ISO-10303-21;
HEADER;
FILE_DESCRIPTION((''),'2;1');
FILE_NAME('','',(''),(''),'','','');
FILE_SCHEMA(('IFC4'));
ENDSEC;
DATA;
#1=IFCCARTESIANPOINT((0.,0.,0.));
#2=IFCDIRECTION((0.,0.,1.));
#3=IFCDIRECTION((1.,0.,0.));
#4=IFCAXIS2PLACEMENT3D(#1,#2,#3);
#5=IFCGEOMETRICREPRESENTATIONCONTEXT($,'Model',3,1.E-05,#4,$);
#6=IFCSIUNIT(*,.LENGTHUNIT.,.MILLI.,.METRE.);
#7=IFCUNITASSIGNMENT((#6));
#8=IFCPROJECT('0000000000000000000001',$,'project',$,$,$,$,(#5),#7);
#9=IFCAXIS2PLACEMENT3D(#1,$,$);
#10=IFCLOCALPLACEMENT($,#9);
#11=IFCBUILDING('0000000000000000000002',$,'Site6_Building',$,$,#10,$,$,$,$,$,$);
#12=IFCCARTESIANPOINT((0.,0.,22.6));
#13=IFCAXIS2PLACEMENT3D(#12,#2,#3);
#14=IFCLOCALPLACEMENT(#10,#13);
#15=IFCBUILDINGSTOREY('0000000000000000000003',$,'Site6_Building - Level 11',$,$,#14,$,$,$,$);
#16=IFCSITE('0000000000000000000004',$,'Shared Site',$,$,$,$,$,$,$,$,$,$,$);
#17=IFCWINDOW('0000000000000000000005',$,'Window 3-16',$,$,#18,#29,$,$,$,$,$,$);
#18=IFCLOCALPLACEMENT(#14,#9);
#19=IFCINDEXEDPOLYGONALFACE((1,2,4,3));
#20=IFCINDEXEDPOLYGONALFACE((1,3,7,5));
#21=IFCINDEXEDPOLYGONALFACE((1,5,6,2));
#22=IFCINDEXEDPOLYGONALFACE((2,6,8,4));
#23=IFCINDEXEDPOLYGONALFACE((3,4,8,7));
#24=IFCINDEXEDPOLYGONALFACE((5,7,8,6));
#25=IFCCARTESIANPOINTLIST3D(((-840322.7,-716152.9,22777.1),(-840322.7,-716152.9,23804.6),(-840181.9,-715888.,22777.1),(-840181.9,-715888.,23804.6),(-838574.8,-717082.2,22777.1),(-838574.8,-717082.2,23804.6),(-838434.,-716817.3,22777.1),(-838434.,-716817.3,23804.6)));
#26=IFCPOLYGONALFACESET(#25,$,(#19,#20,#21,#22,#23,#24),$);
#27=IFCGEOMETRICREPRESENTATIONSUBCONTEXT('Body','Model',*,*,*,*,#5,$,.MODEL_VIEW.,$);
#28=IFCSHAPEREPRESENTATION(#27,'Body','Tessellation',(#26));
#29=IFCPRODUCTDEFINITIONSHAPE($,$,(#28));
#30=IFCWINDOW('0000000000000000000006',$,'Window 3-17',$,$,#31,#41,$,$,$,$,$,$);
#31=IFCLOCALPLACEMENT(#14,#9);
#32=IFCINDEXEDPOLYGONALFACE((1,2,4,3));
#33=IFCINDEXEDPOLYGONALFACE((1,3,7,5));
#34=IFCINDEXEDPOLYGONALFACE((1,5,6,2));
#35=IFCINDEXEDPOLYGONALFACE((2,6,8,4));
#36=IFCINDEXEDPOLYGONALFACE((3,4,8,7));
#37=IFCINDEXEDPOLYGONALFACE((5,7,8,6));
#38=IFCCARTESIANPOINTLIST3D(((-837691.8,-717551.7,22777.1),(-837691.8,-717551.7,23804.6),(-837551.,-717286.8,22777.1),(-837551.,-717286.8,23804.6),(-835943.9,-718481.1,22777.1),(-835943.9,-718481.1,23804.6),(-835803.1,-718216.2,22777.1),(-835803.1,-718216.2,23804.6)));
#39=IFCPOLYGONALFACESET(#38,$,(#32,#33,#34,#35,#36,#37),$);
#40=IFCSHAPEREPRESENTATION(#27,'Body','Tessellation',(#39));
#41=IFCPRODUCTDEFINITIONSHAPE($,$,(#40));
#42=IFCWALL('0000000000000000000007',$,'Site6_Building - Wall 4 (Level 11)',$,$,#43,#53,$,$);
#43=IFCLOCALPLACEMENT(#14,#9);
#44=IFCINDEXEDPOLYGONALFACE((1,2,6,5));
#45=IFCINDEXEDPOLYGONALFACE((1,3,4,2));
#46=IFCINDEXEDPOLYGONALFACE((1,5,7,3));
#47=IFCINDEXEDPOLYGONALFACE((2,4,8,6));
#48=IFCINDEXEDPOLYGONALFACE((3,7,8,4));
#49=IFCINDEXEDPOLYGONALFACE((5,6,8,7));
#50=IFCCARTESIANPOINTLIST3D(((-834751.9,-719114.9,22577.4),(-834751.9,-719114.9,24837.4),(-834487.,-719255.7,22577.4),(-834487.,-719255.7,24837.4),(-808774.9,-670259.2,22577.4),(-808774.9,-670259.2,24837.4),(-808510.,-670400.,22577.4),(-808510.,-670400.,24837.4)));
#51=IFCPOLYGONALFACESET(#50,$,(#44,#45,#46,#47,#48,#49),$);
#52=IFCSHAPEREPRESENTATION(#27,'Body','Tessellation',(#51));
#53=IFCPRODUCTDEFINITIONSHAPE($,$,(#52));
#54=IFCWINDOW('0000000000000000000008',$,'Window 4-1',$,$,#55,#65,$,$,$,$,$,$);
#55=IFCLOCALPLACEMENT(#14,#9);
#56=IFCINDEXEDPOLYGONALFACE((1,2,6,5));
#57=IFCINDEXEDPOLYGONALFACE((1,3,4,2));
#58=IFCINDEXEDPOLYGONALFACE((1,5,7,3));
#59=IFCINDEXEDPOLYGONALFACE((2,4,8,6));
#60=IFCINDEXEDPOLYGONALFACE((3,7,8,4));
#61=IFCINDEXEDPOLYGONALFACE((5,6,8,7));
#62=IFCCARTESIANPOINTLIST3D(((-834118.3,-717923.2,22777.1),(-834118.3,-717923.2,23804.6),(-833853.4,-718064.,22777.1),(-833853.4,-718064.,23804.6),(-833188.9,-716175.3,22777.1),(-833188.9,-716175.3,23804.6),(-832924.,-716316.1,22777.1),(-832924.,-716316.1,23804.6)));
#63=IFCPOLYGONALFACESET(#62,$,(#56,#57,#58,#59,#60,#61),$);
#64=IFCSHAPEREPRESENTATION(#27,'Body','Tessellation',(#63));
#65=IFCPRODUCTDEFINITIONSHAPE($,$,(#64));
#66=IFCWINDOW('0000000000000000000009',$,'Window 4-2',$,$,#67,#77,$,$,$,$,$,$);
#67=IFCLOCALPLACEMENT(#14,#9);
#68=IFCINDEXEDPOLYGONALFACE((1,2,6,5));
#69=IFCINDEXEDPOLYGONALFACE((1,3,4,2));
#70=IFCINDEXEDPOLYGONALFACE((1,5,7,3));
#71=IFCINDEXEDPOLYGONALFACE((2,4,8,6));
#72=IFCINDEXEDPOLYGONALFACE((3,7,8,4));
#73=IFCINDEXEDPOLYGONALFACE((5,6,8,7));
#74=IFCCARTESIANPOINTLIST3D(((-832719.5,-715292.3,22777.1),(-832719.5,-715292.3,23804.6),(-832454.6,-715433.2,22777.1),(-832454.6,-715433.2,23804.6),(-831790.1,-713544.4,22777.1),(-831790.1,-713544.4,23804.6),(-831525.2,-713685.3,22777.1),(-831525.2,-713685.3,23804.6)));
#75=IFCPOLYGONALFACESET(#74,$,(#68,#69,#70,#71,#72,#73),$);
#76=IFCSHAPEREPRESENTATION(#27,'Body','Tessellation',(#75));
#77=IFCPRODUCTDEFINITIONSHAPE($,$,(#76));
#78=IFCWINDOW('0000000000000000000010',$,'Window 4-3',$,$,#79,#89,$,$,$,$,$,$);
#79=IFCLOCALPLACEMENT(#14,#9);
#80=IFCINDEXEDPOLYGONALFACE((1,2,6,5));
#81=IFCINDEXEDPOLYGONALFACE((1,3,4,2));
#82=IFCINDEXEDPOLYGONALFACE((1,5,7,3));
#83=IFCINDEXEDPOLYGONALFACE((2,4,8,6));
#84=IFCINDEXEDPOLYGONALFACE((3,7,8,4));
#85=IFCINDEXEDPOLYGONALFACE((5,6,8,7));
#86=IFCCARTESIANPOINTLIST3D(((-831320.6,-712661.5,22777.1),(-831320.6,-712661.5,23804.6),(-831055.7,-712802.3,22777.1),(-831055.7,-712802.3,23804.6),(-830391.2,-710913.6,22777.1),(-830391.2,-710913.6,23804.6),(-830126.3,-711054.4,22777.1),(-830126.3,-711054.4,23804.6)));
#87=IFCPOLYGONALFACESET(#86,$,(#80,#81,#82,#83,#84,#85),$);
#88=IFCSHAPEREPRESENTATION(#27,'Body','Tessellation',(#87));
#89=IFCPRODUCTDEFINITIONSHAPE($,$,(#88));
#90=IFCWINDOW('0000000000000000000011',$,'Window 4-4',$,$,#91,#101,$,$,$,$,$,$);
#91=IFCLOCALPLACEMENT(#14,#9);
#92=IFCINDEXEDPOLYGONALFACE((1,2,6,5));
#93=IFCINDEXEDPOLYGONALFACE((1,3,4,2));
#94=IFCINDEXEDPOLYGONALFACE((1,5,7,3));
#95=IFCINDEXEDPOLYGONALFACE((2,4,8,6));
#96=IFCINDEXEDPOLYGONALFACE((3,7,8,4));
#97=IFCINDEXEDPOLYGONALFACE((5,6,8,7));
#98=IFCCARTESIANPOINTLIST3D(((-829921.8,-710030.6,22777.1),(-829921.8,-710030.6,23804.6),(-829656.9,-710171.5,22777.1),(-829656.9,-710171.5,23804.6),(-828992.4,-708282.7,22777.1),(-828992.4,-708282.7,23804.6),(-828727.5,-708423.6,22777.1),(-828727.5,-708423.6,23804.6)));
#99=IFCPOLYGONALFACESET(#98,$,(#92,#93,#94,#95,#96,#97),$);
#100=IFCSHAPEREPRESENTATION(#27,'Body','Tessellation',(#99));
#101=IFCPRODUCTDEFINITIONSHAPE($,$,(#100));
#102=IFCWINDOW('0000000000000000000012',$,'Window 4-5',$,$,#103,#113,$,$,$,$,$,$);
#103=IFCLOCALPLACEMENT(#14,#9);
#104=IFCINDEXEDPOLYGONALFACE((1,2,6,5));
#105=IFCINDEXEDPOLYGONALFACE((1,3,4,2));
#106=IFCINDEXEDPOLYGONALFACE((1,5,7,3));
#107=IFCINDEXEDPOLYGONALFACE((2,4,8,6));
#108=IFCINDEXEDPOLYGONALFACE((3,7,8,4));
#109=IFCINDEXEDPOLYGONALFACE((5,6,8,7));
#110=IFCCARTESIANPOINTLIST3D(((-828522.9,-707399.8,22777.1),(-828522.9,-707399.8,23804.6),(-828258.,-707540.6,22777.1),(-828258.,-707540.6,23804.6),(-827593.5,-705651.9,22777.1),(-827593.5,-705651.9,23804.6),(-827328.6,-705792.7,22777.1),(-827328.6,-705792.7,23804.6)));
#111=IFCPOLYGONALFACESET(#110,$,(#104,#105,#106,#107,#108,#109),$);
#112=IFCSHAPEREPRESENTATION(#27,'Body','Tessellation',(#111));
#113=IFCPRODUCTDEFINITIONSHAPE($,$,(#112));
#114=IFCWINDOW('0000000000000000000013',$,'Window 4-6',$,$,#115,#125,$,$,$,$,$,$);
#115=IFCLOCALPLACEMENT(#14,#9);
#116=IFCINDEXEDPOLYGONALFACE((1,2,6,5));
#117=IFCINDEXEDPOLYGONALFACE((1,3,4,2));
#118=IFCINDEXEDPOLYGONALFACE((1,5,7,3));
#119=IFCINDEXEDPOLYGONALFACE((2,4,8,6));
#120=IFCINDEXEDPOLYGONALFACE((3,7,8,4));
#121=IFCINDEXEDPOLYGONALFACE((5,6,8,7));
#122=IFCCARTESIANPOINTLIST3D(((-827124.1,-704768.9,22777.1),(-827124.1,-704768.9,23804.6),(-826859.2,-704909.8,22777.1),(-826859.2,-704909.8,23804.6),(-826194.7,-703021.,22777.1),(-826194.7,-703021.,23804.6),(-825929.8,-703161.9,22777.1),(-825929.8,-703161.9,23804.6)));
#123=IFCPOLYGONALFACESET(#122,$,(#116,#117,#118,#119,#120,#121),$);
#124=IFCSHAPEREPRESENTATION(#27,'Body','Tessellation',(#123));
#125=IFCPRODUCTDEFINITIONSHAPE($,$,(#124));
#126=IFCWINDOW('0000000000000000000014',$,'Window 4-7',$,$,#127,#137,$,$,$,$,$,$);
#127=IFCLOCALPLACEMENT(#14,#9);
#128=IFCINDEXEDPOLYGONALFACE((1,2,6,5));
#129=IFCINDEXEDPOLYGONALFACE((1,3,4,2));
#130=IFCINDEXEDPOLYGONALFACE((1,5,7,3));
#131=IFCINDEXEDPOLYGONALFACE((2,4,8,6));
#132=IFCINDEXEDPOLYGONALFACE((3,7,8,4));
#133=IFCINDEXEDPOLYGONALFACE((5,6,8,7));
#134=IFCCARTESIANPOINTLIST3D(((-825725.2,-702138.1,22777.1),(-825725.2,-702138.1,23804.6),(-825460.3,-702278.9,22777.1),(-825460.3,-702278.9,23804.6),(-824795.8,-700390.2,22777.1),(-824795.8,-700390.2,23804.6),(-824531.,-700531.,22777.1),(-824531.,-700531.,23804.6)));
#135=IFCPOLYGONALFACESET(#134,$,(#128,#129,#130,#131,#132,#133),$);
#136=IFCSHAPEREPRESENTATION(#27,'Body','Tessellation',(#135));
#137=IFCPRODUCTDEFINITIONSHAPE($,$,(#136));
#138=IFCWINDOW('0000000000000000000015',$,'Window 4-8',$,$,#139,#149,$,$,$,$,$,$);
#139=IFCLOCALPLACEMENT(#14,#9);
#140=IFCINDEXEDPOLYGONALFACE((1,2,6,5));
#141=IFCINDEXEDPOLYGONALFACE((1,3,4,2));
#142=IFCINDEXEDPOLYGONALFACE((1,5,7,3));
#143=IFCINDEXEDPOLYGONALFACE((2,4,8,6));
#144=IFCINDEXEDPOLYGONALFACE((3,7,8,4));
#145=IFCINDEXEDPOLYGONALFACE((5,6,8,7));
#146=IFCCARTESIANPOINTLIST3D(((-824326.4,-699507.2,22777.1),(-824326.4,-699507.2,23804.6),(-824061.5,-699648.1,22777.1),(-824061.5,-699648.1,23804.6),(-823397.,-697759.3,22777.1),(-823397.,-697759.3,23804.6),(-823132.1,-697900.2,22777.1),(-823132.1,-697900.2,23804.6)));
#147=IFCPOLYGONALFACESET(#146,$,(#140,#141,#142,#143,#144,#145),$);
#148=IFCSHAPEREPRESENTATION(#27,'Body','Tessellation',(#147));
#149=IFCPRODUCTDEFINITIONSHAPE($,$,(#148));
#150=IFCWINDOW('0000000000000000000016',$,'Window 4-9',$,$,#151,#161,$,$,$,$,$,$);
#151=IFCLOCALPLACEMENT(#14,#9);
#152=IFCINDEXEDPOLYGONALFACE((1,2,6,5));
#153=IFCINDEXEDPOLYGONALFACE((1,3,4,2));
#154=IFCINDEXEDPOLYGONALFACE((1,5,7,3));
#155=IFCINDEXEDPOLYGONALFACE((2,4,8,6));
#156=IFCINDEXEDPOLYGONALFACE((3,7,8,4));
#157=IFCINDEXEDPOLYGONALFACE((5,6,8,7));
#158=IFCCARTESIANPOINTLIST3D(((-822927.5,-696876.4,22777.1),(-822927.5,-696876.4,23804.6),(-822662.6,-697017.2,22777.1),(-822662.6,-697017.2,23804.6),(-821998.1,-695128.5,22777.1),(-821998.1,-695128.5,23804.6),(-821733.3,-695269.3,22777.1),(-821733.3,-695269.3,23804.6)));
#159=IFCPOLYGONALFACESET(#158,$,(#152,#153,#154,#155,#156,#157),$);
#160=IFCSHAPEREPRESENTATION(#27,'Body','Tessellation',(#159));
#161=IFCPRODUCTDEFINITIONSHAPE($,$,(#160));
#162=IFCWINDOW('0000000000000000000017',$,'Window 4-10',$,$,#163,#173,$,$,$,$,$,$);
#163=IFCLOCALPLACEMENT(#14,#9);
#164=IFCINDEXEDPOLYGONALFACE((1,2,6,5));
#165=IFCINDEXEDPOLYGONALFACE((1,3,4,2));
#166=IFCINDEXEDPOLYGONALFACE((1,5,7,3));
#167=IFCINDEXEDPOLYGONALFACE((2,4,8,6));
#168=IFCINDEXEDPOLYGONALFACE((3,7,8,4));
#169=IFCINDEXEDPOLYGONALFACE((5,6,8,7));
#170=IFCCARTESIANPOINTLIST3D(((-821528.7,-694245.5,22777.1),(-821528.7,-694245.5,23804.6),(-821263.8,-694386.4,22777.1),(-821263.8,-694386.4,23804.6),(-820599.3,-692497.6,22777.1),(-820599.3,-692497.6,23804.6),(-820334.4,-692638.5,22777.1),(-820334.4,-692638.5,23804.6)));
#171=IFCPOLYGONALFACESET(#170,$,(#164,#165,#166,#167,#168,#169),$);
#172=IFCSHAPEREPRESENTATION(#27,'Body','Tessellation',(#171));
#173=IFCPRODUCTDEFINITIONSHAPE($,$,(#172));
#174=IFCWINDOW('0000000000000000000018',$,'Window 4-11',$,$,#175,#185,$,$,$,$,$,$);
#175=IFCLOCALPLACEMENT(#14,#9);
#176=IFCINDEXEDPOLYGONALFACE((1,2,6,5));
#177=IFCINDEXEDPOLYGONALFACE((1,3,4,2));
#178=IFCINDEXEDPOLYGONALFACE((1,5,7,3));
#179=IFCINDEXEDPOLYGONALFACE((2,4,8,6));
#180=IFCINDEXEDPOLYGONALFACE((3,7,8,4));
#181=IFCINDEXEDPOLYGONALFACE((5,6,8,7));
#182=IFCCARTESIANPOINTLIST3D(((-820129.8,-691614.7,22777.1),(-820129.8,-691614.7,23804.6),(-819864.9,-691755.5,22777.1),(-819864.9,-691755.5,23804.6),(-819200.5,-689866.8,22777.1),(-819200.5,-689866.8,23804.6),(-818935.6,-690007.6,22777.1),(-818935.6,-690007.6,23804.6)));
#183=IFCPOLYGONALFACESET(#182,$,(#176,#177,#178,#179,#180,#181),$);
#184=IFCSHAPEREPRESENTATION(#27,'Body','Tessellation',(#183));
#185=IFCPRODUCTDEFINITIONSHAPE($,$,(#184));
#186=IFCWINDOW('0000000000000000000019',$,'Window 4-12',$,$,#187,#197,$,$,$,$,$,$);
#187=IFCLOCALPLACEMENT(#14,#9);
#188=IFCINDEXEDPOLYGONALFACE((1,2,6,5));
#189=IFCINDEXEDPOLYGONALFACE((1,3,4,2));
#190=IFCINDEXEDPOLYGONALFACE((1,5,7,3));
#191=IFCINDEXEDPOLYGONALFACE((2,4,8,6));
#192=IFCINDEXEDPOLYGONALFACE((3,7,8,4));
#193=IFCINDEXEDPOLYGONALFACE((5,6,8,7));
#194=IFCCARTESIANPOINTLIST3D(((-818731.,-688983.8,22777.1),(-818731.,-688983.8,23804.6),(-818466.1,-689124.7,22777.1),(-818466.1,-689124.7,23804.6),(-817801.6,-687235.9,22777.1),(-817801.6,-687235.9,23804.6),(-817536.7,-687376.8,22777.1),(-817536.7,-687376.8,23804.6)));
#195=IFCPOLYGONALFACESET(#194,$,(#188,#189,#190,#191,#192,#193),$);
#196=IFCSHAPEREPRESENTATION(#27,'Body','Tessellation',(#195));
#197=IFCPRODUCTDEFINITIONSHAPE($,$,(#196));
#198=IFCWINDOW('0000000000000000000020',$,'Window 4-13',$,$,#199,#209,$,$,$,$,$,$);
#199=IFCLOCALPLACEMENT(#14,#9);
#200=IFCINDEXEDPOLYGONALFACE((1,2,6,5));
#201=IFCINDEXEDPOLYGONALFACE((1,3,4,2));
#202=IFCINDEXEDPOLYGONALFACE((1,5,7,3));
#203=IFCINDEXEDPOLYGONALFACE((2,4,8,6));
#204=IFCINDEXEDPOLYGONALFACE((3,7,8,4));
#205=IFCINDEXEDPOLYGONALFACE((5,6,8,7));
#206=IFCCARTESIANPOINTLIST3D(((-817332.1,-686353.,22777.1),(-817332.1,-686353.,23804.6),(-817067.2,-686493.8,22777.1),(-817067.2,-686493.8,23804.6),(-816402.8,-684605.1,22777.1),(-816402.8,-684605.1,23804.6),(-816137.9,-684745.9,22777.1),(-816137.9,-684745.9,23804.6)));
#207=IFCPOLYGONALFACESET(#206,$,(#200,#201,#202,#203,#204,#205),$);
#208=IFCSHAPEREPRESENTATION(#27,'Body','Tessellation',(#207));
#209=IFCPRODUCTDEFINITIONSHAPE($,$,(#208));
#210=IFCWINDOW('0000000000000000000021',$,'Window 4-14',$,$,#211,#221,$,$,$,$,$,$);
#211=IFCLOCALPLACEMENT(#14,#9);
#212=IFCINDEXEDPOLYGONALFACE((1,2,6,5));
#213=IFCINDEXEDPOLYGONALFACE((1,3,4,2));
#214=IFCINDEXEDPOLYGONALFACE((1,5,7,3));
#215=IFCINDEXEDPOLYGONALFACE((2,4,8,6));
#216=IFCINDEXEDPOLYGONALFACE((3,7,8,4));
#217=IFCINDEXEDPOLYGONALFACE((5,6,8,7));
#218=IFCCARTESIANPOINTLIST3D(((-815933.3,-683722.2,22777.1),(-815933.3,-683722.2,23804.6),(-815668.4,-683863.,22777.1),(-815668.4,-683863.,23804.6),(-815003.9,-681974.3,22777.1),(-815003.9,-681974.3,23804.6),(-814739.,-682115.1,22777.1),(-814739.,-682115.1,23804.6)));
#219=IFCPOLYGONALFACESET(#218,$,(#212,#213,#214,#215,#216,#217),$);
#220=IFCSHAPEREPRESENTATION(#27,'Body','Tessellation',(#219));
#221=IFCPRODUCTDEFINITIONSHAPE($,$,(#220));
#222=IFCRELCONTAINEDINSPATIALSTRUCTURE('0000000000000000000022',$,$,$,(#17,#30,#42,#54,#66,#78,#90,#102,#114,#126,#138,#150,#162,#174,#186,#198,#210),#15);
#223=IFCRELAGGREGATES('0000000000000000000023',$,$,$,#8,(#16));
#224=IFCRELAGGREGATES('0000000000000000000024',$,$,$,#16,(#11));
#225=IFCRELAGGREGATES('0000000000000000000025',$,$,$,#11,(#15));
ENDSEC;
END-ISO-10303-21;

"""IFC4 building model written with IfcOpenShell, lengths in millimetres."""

from ifc_helpers import new_model, si_unit, frame, origin, origin_with_axes, place, context, subcontext, project, spatial, indexed_curve, outline, extrude, element, save


model = new_model("IFC4")

# Units and contexts
model_context = context("Model", 3, precision=1e-05, world=origin_with_axes())
body_context = subcontext(model_context, "Body", "Model", "MODEL_VIEW")
ifc_project = project(units=[si_unit("LENGTHUNIT", "METRE", prefix="MILLI")], contexts=[model_context])

# Site, building, storey
site = spatial("IfcSite", under=ifc_project, Name="Shared Site")
building_placement = place(None, origin())
building = spatial("IfcBuilding", under=site, at=building_placement, Name="Site6_Building")
storey_placement = place(building_placement, frame((0.0, 0.0, 22.6), z_axis=(0.0, 0.0, 1.0), x_axis=(1.0, 0.0, 0.0)))
storey = spatial("IfcBuildingStorey", under=building, at=storey_placement, Name="Site6_Building - Level 11")

# Windows
for number, where, z_axis, x_axis, name in (
    (1, (-840322.7, -716152.9, 22777.1), (0.0, 0.0, 1.0), (0.882948, -0.469472, 0.0), "Window 3-16"),
    (2, (-837691.8, -717551.7, 22777.1), (0.0, 0.0, 1.0), (0.882948, -0.469472, 0.0), "Window 3-17"),
):
    element("IfcWindow", number, at=place(storey_placement, frame(where, z_axis=z_axis, x_axis=x_axis)), inside=storey, Name=name, context=body_context, shape_type="SweptSolid", body=[
        extrude(outline(indexed_curve([(0.0, 0.0), (0.0, 300.0), (1979.6, 300.0), (1979.6, 0.0), (0.0, 0.0)], self_intersect=False)), origin_with_axes(), (0.0, 0.0, 1.0), 1027.5),
    ])

# Wall
wall_1_placement = place(storey_placement, frame((-834487.0, -719255.7, 22577.4), z_axis=(0.0, 0.0, 1.0), x_axis=(0.469472, 0.882948, 0.0)))
element("IfcWall", 3, at=wall_1_placement, inside=storey, Name="Site6_Building - Wall 4 (Level 11)", context=body_context, shape_type="SweptSolid", body=[
    extrude(outline(indexed_curve([(0.0, 0.0), (0.0, 300.0), (55332.5, 300.0), (55332.5, 0.0), (0.0, 0.0)], self_intersect=False)), origin_with_axes(), (0.0, 0.0, 1.0), 2260.0),
])

# Windows
for number, where, z_axis, x_axis, name in (
    (4, (-833853.4, -718064.0, 22777.1), (0.0, 0.0, 1.0), (0.469472, 0.882948, 0.0), "Window 4-1"),
    (5, (-832454.6, -715433.2, 22777.1), (0.0, 0.0, 1.0), (0.469472, 0.882948, 0.0), "Window 4-2"),
    (6, (-831055.7, -712802.3, 22777.1), (0.0, 0.0, 1.0), (0.469472, 0.882948, 0.0), "Window 4-3"),
    (7, (-829656.9, -710171.5, 22777.1), (0.0, 0.0, 1.0), (0.469472, 0.882948, 0.0), "Window 4-4"),
    (8, (-828258.0, -707540.6, 22777.1), (0.0, 0.0, 1.0), (0.469472, 0.882948, 0.0), "Window 4-5"),
    (9, (-826859.2, -704909.8, 22777.1), (0.0, 0.0, 1.0), (0.469472, 0.882948, 0.0), "Window 4-6"),
    (10, (-825460.3, -702278.9, 22777.1), (0.0, 0.0, 1.0), (0.469472, 0.882948, 0.0), "Window 4-7"),
    (11, (-824061.5, -699648.1, 22777.1), (0.0, 0.0, 1.0), (0.469472, 0.882948, 0.0), "Window 4-8"),
    (12, (-822662.6, -697017.2, 22777.1), (0.0, 0.0, 1.0), (0.469472, 0.882948, 0.0), "Window 4-9"),
    (13, (-821263.8, -694386.4, 22777.1), (0.0, 0.0, 1.0), (0.469472, 0.882948, 0.0), "Window 4-10"),
    (14, (-819864.9, -691755.5, 22777.1), (0.0, 0.0, 1.0), (0.469472, 0.882948, 0.0), "Window 4-11"),
    (15, (-818466.1, -689124.7, 22777.1), (0.0, 0.0, 1.0), (0.469472, 0.882948, 0.0), "Window 4-12"),
    (16, (-817067.2, -686493.8, 22777.1), (0.0, 0.0, 1.0), (0.469472, 0.882948, 0.0), "Window 4-13"),
    (17, (-815668.4, -683863.0, 22777.1), (0.0, 0.0, 1.0), (0.469472, 0.882948, 0.0), "Window 4-14"),
):
    element("IfcWindow", number, at=place(storey_placement, frame(where, z_axis=z_axis, x_axis=x_axis)), inside=storey, Name=name, context=body_context, shape_type="SweptSolid", body=[
        extrude(outline(indexed_curve([(0.0, 0.0), (0.0, 300.0), (1979.6, 300.0), (1979.6, 0.0), (0.0, 0.0)], self_intersect=False)), origin_with_axes(), (0.0, 0.0, 1.0), 1027.5),
    ])

save(model, "model.ifc")
